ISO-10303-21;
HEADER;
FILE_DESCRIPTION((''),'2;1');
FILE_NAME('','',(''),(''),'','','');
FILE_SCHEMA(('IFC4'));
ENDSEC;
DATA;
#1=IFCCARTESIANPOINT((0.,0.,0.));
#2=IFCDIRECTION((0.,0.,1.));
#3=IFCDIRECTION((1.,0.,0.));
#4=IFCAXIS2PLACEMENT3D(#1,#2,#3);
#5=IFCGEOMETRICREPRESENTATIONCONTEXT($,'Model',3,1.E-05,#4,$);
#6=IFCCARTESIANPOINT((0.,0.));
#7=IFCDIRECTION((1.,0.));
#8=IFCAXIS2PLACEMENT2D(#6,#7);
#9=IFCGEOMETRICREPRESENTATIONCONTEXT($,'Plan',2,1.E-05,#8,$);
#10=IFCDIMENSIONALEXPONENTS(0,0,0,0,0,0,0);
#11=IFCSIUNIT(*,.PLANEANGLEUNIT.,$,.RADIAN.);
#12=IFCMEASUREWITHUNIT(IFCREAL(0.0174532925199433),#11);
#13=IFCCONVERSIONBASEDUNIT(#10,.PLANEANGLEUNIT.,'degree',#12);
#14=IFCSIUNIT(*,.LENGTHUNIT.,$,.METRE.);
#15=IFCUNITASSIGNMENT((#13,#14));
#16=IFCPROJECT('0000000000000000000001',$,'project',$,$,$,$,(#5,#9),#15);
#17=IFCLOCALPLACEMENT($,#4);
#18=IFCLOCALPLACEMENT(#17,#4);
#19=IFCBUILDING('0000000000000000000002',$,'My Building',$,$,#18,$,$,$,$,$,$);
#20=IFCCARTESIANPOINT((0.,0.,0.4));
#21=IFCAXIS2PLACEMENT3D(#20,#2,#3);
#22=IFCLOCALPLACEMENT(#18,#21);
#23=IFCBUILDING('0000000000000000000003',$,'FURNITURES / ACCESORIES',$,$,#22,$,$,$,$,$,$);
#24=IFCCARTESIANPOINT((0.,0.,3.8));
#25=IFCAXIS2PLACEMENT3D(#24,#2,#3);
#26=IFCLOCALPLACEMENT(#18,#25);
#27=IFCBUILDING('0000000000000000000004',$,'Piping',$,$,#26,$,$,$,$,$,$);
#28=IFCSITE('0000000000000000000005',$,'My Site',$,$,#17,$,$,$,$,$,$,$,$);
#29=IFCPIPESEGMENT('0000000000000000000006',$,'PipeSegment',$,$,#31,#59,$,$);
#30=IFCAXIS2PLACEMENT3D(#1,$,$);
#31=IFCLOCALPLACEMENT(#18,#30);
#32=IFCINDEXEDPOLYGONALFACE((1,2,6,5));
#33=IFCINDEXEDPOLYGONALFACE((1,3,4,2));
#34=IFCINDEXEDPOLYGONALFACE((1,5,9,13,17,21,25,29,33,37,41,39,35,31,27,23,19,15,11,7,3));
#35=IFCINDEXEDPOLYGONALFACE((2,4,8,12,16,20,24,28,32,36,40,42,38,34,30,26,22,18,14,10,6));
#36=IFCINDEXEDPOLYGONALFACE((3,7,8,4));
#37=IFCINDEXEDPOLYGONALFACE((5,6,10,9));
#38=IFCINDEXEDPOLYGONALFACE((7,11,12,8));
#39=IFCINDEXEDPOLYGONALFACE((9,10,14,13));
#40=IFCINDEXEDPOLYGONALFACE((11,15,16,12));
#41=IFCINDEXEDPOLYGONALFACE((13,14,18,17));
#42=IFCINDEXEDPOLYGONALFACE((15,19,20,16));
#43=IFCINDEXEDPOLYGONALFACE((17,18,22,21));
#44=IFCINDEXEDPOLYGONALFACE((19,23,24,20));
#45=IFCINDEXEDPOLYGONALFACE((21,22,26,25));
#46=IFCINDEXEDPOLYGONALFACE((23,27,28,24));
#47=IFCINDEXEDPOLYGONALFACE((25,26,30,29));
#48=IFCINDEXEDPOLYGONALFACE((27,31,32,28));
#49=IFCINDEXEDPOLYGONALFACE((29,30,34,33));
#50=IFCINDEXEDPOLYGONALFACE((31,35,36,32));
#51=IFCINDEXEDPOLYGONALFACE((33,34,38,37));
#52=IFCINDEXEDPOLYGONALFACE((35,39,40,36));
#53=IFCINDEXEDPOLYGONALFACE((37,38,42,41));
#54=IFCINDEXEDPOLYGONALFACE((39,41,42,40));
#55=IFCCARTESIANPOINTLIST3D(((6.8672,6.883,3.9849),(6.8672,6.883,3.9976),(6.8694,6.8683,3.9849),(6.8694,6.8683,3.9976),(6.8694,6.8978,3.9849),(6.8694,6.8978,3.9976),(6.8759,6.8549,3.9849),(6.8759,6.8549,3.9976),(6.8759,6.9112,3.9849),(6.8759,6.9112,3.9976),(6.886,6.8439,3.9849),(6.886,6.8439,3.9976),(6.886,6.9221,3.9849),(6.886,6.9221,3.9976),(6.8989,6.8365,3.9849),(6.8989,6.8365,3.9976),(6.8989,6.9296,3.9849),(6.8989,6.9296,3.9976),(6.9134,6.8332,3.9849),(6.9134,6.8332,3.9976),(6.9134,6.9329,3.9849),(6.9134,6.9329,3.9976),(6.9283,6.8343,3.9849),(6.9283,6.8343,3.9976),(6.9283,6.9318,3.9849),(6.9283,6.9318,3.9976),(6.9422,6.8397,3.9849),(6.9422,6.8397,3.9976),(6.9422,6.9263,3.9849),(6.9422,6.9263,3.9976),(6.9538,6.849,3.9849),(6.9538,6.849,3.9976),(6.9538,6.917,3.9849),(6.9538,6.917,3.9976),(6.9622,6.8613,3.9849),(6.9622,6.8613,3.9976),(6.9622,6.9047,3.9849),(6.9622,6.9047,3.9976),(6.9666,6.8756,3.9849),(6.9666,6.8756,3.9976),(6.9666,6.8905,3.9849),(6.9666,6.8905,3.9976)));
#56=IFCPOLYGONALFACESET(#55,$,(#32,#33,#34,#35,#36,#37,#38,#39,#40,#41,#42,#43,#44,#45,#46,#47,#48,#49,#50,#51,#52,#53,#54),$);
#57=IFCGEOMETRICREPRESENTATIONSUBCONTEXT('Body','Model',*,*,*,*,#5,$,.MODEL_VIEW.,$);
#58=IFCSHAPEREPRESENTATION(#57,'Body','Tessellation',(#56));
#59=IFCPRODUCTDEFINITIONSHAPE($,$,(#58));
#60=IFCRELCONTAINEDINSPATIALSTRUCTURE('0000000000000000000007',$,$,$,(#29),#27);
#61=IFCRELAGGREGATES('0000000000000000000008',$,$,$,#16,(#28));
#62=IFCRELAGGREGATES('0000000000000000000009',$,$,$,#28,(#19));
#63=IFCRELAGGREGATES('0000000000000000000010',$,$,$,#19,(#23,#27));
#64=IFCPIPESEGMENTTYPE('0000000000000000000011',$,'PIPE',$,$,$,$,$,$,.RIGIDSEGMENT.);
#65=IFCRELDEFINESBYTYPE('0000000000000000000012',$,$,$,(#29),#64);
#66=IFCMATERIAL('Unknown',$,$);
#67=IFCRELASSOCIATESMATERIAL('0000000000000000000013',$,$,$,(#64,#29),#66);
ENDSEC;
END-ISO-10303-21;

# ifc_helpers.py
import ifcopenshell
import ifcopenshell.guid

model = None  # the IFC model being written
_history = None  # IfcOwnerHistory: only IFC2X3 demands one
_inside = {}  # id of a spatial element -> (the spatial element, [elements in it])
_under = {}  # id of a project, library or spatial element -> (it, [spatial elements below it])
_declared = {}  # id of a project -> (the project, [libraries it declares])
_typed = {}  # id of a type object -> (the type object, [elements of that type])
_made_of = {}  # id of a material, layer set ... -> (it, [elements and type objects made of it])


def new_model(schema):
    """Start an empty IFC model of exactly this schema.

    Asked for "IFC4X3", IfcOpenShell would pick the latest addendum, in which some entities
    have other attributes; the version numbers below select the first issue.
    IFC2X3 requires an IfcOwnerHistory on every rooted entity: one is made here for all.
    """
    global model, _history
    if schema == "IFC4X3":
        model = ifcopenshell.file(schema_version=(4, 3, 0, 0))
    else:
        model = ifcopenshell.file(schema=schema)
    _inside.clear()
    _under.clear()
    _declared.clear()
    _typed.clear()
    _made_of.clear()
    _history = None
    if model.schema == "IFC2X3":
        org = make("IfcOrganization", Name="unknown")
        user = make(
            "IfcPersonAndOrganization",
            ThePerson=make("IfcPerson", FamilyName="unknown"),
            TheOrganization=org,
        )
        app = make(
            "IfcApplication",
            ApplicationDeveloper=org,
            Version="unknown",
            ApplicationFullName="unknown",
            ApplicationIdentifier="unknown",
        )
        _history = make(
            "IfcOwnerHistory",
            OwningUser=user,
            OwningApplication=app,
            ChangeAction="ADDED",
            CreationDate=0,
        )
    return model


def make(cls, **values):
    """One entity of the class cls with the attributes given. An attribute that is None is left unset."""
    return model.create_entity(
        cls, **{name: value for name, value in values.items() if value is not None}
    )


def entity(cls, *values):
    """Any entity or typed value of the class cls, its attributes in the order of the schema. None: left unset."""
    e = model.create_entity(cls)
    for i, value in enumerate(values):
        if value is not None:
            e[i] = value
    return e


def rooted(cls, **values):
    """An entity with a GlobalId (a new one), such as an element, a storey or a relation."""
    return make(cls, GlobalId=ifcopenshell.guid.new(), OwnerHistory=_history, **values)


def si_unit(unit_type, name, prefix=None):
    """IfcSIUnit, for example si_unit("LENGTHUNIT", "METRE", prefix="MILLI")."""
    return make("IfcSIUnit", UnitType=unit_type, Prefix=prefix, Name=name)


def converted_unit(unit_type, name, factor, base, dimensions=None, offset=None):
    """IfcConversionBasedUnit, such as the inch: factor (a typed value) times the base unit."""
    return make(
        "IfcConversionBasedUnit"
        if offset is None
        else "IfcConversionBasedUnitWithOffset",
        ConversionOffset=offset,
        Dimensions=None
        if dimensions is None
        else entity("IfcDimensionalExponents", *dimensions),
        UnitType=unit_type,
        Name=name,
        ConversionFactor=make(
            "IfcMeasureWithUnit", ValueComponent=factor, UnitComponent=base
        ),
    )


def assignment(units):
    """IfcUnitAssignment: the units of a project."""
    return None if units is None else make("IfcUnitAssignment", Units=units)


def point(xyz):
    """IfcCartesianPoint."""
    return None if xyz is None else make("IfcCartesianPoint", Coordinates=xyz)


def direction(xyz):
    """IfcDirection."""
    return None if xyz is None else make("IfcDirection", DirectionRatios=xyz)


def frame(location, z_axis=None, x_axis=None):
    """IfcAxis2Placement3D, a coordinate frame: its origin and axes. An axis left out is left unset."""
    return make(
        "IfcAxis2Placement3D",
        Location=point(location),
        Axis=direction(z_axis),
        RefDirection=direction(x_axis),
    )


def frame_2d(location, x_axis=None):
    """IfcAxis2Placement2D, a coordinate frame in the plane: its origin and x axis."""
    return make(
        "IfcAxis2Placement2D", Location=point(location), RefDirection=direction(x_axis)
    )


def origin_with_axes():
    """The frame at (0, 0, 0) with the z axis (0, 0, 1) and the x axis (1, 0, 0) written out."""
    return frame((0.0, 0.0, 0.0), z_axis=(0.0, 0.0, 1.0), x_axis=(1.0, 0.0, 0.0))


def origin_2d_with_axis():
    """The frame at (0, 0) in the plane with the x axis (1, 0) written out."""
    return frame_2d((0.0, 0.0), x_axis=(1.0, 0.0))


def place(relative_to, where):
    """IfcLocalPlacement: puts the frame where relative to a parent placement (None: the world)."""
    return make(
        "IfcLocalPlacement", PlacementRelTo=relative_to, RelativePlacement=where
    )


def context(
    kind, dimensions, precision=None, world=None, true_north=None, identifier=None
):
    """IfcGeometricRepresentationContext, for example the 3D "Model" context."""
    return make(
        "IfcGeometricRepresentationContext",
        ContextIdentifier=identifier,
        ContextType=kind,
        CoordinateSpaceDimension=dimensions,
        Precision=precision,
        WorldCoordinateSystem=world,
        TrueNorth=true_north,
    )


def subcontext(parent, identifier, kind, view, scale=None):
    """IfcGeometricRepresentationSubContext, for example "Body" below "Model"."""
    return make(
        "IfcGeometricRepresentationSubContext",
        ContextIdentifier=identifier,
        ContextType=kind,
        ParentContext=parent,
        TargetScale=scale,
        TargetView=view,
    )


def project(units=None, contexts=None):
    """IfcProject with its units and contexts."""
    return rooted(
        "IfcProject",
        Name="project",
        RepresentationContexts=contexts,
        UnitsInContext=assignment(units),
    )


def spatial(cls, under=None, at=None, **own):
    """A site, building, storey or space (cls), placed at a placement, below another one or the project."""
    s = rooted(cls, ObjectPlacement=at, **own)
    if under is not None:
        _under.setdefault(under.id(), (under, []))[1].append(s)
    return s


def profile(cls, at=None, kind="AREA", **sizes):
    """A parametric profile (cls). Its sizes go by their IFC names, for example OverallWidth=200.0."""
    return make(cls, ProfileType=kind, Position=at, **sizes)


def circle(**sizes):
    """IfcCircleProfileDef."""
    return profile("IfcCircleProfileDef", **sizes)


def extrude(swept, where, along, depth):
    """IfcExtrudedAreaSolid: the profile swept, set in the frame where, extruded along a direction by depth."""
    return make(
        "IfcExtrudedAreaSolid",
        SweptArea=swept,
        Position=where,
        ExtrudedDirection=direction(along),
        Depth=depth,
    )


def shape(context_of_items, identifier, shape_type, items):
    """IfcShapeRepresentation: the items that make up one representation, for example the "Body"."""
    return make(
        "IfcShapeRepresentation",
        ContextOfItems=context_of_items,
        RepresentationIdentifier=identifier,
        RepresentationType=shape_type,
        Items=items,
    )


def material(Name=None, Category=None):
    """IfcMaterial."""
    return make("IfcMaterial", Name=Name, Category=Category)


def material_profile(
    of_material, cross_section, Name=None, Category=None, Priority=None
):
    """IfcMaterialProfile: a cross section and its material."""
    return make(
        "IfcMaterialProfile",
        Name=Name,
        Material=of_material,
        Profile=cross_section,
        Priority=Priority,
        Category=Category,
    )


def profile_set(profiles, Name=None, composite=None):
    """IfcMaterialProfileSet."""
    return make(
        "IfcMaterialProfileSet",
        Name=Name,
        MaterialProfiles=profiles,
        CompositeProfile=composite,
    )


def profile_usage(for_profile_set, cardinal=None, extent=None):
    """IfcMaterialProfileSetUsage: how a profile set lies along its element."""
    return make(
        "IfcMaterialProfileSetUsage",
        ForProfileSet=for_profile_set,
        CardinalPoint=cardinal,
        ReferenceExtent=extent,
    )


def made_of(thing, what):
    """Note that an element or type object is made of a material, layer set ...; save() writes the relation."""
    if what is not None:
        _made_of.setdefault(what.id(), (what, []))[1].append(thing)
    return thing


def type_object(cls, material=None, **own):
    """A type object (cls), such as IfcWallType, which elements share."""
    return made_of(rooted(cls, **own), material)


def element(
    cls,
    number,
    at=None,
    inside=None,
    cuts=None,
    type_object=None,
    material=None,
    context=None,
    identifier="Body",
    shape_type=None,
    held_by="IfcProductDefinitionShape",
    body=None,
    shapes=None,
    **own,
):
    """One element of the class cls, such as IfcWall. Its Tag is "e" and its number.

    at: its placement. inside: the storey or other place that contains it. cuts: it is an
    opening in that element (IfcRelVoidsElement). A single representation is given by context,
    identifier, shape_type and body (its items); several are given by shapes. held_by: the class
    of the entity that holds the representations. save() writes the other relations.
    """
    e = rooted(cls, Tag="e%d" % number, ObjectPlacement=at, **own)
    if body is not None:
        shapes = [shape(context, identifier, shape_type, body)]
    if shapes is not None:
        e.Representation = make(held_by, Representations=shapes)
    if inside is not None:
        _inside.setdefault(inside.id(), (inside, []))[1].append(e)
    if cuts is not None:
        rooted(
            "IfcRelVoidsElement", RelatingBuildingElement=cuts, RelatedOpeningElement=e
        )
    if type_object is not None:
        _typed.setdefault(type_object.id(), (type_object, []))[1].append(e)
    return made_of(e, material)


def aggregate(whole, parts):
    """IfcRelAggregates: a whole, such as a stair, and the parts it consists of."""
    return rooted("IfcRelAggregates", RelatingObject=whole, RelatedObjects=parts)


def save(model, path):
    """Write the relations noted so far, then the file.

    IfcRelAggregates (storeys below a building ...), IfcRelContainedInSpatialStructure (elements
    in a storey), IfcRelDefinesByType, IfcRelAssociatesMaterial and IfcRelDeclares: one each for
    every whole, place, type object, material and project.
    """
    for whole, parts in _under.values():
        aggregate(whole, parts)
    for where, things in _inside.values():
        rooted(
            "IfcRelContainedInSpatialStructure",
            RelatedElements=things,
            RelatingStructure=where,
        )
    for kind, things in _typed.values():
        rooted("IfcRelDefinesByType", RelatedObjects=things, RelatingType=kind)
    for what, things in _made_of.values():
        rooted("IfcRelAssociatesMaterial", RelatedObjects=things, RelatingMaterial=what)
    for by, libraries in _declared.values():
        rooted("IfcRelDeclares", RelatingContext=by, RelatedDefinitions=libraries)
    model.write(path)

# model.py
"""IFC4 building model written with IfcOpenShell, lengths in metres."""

from ifc_helpers import new_model, entity, si_unit, converted_unit, frame, origin_with_axes, origin_2d_with_axis, place, context, subcontext, project, spatial, circle, extrude, material, material_profile, profile_set, profile_usage, type_object, element, save


model = new_model("IFC4")

# Units and contexts
model_context = context("Model", 3, precision=1e-05, world=origin_with_axes())
plan_context = context("Plan", 2, precision=1e-05, world=origin_2d_with_axis())
body_context = subcontext(model_context, "Body", "Model", "MODEL_VIEW")
ifc_project = project(units=[converted_unit("PLANEANGLEUNIT", "degree", entity("IfcReal", 0.0174532925199433), si_unit("PLANEANGLEUNIT", "RADIAN"), dimensions=[0, 0, 0, 0, 0, 0, 0]), si_unit("LENGTHUNIT", "METRE")], contexts=[model_context, plan_context])

# Site, building
site_placement = place(None, origin_with_axes())
site = spatial("IfcSite", under=ifc_project, at=site_placement, Name="My Site")
building_1_placement = place(site_placement, origin_with_axes())
building_1 = spatial("IfcBuilding", under=site, at=building_1_placement, Name="My Building")

# Shared definitions
ifc_material = material(Name="Unknown")

# Shared definitions
building_2_placement = place(building_1_placement, frame((0.0, 0.0, 0.4), z_axis=(0.0, 0.0, 1.0), x_axis=(1.0, 0.0, 0.0)))
building_2 = spatial("IfcBuilding", under=building_1, at=building_2_placement, Name="FURNITURES / ACCESORIES")

# Shared definitions
building_3_placement = place(building_1_placement, frame((0.0, 0.0, 3.8), z_axis=(0.0, 0.0, 1.0), x_axis=(1.0, 0.0, 0.0)))
building_3 = spatial("IfcBuilding", under=building_1, at=building_3_placement, Name="Piping")

# Pipe segment
ifc_material_profile = material_profile(ifc_material, circle(Radius=0.05))
ifc_profile_set = profile_set([ifc_material_profile])
pipe_segment_type = type_object("IfcPipeSegmentType", Name="PIPE", PredefinedType="RIGIDSEGMENT", material=ifc_profile_set)
ifc_profile_usage_1 = profile_usage(ifc_profile_set, cardinal=5)
pipe_segment_1_placement = place(building_3_placement, frame((6.9172, 6.883, 0.1976), z_axis=(0.0, 0.0, -1.0), x_axis=(-1.0, 0.0, 0.0)))
element("IfcPipeSegment", 1, at=pipe_segment_1_placement, inside=building_3, type_object=pipe_segment_type, material=ifc_profile_usage_1, Name="PipeSegment", context=body_context, shape_type="SweptSolid", body=[
    extrude(circle(Radius=0.05), origin_with_axes(), (0.0, 0.0, 1.0), 0.0127),
])

save(model, "model.ifc")
